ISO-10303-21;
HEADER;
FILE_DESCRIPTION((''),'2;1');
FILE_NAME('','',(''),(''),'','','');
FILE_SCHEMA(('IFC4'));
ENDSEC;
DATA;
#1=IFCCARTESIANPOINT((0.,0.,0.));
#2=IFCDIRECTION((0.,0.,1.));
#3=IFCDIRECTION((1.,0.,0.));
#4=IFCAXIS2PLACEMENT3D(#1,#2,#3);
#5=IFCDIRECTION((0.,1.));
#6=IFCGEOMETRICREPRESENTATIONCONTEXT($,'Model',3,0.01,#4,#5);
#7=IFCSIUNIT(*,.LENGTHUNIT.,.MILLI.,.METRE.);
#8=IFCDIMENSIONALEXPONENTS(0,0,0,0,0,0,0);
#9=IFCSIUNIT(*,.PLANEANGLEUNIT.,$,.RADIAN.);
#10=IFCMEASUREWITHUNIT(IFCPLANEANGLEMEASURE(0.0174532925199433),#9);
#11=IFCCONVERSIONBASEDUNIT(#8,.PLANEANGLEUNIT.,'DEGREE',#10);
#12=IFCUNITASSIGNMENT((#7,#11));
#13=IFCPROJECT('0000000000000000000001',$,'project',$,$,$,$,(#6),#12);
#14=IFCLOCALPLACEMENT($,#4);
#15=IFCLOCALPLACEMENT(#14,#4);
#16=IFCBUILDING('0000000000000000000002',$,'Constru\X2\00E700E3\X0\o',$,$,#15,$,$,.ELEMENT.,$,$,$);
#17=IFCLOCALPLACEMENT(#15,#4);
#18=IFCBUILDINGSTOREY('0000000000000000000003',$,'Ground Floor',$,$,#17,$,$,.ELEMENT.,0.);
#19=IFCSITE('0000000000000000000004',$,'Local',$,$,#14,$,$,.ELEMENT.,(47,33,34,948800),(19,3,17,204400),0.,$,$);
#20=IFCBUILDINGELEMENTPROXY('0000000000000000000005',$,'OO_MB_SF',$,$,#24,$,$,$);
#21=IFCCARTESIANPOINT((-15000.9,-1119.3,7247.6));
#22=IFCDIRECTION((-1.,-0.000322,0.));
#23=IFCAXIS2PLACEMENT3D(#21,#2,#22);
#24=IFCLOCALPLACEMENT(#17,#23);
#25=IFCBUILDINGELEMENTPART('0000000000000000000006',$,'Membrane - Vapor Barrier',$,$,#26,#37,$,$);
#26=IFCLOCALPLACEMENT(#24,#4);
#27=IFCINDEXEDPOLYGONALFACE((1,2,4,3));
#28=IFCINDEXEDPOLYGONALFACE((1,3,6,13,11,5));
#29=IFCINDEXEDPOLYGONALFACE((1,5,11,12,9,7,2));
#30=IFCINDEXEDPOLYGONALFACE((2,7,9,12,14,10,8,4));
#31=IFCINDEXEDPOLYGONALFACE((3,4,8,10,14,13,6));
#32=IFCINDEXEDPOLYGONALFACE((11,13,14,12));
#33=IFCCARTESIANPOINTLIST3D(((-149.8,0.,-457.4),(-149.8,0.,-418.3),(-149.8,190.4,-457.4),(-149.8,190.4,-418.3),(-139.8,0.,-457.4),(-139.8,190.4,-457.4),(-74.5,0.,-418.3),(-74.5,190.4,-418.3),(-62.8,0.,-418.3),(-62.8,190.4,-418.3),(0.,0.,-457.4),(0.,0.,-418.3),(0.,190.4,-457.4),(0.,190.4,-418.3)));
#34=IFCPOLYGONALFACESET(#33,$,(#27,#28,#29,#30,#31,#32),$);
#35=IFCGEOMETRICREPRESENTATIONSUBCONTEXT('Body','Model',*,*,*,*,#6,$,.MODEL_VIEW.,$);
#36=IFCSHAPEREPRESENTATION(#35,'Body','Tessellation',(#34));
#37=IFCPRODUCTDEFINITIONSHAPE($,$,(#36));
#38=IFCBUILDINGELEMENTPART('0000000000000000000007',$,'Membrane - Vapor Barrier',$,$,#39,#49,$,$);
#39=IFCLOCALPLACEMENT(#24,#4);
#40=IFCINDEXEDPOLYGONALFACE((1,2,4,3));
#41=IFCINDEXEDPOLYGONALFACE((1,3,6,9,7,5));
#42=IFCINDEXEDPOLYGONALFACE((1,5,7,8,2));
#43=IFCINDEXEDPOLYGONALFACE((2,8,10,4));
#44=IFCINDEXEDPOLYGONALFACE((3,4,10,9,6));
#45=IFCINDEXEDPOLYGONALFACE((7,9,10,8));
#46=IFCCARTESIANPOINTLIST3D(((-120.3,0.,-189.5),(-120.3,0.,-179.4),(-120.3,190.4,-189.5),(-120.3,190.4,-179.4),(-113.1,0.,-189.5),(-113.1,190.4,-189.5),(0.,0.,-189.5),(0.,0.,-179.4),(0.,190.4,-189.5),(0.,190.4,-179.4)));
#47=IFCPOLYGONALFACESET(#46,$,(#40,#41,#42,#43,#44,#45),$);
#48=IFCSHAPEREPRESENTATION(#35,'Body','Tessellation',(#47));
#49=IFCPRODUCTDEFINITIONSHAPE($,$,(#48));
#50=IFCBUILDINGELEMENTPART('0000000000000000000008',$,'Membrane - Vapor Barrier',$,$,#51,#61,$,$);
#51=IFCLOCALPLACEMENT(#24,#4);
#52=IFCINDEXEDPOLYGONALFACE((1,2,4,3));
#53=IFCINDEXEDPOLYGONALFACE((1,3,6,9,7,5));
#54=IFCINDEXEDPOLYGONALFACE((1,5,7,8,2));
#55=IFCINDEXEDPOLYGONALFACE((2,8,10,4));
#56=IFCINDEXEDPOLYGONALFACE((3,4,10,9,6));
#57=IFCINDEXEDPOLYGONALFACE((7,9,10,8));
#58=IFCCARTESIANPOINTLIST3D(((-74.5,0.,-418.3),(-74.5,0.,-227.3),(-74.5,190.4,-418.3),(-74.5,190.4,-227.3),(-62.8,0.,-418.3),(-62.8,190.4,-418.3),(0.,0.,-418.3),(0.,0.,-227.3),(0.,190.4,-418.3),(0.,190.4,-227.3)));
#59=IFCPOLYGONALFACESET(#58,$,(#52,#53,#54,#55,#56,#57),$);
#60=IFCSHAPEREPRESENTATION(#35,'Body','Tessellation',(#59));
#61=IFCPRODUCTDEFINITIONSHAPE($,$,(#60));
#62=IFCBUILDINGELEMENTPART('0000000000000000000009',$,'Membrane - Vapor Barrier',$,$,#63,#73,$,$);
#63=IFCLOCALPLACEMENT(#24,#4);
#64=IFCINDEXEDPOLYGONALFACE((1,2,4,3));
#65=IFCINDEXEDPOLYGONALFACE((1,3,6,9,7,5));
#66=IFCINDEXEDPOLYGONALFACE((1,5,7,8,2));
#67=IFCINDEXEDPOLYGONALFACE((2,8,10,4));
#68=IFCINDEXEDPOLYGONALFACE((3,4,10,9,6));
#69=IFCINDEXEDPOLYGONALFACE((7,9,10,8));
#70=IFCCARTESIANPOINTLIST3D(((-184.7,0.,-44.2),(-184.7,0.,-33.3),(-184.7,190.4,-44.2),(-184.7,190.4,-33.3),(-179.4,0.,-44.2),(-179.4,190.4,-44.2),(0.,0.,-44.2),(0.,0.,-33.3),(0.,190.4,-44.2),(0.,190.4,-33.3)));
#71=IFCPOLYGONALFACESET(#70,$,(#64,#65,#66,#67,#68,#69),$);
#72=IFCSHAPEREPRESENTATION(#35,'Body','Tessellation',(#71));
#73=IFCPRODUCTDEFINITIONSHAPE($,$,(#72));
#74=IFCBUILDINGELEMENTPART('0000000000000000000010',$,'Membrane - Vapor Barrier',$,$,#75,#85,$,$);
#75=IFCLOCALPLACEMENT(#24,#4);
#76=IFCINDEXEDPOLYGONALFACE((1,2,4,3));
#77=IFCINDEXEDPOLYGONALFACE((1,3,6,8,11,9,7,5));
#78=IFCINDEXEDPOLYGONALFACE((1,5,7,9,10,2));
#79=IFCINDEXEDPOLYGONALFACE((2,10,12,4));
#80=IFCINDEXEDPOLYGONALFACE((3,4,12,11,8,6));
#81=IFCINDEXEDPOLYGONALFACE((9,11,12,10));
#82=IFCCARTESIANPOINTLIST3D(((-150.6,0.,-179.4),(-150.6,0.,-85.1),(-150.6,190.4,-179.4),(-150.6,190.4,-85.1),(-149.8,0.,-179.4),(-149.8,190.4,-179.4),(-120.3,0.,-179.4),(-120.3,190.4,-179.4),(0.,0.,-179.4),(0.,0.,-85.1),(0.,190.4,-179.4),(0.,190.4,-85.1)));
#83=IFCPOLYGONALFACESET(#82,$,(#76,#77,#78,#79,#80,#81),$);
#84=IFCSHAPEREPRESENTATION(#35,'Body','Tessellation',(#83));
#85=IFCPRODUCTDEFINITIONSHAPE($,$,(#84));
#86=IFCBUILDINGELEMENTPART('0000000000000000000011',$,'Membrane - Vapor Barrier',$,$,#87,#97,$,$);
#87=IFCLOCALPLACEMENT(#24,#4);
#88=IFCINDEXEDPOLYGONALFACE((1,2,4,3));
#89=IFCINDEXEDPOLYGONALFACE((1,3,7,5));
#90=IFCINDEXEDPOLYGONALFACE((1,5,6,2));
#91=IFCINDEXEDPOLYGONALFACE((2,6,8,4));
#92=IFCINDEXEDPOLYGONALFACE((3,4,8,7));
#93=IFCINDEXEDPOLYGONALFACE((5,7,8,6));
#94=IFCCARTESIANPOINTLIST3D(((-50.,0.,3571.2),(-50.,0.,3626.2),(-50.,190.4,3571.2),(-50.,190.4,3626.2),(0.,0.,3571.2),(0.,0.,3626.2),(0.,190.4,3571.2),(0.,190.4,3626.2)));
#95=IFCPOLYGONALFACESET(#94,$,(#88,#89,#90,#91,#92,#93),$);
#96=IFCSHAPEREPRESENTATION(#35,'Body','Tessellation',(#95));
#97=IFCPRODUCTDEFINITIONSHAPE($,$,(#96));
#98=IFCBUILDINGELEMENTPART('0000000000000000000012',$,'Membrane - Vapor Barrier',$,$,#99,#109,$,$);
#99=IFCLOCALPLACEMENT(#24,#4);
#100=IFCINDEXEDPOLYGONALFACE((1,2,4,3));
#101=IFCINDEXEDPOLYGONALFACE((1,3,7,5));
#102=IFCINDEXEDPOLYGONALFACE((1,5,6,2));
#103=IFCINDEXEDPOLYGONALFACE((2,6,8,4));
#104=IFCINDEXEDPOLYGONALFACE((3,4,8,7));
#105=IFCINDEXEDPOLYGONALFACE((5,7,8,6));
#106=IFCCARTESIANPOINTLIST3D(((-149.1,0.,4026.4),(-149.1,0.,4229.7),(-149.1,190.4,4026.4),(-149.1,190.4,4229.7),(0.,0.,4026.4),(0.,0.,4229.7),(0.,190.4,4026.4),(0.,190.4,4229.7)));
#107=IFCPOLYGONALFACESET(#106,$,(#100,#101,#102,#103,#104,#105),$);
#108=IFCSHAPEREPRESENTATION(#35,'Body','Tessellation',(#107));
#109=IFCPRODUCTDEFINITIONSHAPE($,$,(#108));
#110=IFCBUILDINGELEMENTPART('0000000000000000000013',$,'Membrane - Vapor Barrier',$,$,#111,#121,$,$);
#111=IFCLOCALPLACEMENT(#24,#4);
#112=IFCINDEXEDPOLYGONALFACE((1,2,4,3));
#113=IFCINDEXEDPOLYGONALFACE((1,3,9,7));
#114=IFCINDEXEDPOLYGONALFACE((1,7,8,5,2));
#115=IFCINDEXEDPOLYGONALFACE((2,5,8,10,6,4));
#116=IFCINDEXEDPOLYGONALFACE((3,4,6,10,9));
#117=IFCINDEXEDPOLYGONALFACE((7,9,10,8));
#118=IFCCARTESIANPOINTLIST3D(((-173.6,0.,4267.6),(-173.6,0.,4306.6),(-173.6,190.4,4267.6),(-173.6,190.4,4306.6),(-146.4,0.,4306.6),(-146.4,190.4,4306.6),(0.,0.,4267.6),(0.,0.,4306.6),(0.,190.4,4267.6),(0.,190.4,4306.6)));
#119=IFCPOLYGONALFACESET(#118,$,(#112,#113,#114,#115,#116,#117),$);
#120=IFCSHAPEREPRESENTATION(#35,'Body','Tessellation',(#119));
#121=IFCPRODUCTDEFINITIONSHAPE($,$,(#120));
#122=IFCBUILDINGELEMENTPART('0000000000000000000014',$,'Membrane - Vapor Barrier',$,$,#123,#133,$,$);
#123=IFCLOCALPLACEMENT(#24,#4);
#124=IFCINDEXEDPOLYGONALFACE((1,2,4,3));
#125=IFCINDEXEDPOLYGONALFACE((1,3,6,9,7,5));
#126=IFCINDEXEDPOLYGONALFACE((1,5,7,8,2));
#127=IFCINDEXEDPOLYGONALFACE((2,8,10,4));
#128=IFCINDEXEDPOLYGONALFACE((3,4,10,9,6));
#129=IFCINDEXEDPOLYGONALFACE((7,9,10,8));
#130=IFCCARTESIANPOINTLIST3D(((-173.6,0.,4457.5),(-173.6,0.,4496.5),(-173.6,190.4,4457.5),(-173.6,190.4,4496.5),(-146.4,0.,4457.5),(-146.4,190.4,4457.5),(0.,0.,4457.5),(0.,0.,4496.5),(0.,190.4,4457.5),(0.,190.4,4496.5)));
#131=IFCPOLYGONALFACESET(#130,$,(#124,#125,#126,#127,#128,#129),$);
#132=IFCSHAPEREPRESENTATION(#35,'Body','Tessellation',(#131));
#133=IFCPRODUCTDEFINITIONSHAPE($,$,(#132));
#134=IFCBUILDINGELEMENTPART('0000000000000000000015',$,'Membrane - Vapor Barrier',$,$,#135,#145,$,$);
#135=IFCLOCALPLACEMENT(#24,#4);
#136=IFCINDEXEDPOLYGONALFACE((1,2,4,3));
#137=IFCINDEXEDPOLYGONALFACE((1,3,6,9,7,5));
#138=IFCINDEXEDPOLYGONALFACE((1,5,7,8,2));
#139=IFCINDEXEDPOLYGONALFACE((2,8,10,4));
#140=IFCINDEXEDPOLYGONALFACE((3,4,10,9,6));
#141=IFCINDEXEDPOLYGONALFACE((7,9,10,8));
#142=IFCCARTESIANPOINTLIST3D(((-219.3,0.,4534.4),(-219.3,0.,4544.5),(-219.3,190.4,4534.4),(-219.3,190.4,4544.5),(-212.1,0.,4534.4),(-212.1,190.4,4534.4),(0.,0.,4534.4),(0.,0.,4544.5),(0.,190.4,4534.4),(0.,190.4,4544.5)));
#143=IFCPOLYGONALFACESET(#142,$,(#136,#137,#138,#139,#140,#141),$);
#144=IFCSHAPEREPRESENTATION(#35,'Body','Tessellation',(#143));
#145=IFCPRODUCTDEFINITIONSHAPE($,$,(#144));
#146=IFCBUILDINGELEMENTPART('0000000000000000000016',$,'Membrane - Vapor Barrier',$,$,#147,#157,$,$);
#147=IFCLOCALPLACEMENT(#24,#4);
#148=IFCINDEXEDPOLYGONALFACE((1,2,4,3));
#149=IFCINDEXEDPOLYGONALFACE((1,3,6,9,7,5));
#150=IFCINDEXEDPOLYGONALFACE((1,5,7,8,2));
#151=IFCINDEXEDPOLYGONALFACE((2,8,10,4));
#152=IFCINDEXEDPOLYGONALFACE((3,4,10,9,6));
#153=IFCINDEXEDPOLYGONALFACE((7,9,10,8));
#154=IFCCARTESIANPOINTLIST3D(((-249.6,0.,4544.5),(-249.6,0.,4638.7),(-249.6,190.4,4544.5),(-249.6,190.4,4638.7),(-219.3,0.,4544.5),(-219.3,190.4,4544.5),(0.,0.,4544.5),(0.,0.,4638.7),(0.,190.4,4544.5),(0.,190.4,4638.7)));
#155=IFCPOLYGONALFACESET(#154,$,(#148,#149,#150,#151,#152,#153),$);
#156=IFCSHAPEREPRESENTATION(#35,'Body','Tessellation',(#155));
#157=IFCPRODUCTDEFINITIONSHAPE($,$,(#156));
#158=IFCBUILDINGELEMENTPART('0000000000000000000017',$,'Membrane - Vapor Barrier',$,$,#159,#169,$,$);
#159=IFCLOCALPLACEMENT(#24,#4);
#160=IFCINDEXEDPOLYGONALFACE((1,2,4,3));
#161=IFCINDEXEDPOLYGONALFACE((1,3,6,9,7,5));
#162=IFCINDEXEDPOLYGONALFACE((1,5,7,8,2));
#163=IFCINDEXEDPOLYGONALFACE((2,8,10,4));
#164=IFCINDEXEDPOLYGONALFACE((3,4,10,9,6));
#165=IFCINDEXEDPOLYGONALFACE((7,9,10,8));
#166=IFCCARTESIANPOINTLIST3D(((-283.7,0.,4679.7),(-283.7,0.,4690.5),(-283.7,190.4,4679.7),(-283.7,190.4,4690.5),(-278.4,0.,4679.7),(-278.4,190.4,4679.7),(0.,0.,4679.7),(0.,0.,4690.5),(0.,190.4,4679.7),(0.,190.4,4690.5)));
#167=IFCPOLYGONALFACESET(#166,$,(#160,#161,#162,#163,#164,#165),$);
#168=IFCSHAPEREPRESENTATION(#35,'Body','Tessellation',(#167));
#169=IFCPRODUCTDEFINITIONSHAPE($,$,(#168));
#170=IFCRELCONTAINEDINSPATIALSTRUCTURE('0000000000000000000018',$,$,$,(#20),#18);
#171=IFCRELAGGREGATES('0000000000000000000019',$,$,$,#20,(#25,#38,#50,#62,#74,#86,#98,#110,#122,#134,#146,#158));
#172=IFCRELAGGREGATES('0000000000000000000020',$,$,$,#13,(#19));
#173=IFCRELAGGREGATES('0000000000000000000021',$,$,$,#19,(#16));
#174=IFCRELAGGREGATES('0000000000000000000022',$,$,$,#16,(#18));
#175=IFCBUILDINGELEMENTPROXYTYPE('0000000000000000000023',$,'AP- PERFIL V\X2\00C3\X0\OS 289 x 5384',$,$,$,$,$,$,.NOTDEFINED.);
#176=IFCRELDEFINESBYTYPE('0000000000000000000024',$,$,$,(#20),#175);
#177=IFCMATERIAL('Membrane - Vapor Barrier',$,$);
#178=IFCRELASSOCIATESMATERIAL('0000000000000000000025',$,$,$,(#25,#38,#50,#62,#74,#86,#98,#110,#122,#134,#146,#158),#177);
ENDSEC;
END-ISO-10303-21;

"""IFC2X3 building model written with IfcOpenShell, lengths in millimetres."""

from ifc_helpers import new_model, entity, si_unit, converted_unit, direction, frame, origin_with_axes, place, context, subcontext, project, spatial, polyline, outline, extrude, material, type_object, element, aggregate, save


model = new_model("IFC2X3")

# Units and contexts
model_context = context("Model", 3, precision=0.01, world=origin_with_axes(), true_north=direction((0.0, 1.0)))
body_context = subcontext(model_context, "Body", "Model", "MODEL_VIEW")
ifc_project = project(units=[si_unit("LENGTHUNIT", "METRE", prefix="MILLI"), converted_unit("PLANEANGLEUNIT", "DEGREE", entity("IfcPlaneAngleMeasure", 0.0174532925199433), si_unit("PLANEANGLEUNIT", "RADIAN"), dimensions=[0, 0, 0, 0, 0, 0, 0])], contexts=[model_context])

# Site, building, storey
site_placement = place(None, origin_with_axes())
site = spatial("IfcSite", under=ifc_project, at=site_placement, Name="Local", CompositionType="ELEMENT", RefLatitude=(47, 33, 34, 948800), RefLongitude=(19, 3, 17, 204400), RefElevation=0.0)
building_placement = place(site_placement, origin_with_axes())
building = spatial("IfcBuilding", under=site, at=building_placement, Name="Construção", CompositionType="ELEMENT")
storey_placement = place(building_placement, origin_with_axes())
storey = spatial("IfcBuildingStorey", under=building, at=storey_placement, Name="Ground Floor", CompositionType="ELEMENT", Elevation=0.0)

# Building element proxy
building_element_proxy_type = type_object("IfcBuildingElementProxyType", Name="AP- PERFIL VÃOS 289 x 5384", PredefinedType="NOTDEFINED")
ifc_material = material(Name="Membrane - Vapor Barrier")
proxy_1_placement = place(storey_placement, frame((-15000.9, -1119.3, 7247.6), z_axis=(0.0, 0.0, 1.0), x_axis=(-1.0, -0.000322, 0.0)))
proxy_1 = element("IfcBuildingElementProxy", 1, at=proxy_1_placement, inside=storey, type_object=building_element_proxy_type, Name="OO_MB_SF")

# Building element parts
building_element_part_1_placement = place(proxy_1_placement, origin_with_axes())
building_element_part_1 = element("IfcBuildingElementPart", 2, at=building_element_part_1_placement, material=ifc_material, Name="Membrane - Vapor Barrier", context=body_context, shape_type="SweptSolid", body=[
    extrude(outline(polyline([(62.8, -418.3), (0.0, -418.3), (0.0, -457.4), (139.8, -457.4), (149.8, -457.4), (149.8, -418.3), (74.5, -418.3), (62.8, -418.3)])), frame((0.0, 190.4, 0.0), z_axis=(0.0, 1.0, 0.0), x_axis=(-1.0, 0.0, 0.0)), (0.0, 0.0, -1.0), 190.4),
])
building_element_part_2_placement = place(proxy_1_placement, origin_with_axes())
building_element_part_2 = element("IfcBuildingElementPart", 3, at=building_element_part_2_placement, material=ifc_material, Name="Membrane - Vapor Barrier", context=body_context, shape_type="SweptSolid", body=[
    extrude(outline(polyline([(120.3, -179.4), (0.0, -179.4), (0.0, -189.5), (113.1, -189.5), (120.3, -189.5), (120.3, -179.4)])), frame((0.0, 190.4, 0.0), z_axis=(0.0, 1.0, 0.0), x_axis=(-1.0, 0.0, 0.0)), (0.0, 0.0, -1.0), 190.4),
])
building_element_part_3_placement = place(proxy_1_placement, origin_with_axes())
building_element_part_3 = element("IfcBuildingElementPart", 4, at=building_element_part_3_placement, material=ifc_material, Name="Membrane - Vapor Barrier", context=body_context, shape_type="SweptSolid", body=[
    extrude(outline(polyline([(0.0, -227.3), (0.0, -418.3), (62.8, -418.3), (74.5, -418.3), (74.5, -227.3), (0.0, -227.3)])), frame((0.0, 190.4, 0.0), z_axis=(0.0, 1.0, 0.0), x_axis=(-1.0, 0.0, 0.0)), (0.0, 0.0, -1.0), 190.4),
])
building_element_part_4_placement = place(proxy_1_placement, origin_with_axes())
building_element_part_4 = element("IfcBuildingElementPart", 5, at=building_element_part_4_placement, material=ifc_material, Name="Membrane - Vapor Barrier", context=body_context, shape_type="SweptSolid", body=[
    extrude(outline(polyline([(184.7, -33.3), (0.0, -33.3), (0.0, -44.2), (179.4, -44.2), (184.7, -44.2), (184.7, -33.3)])), frame((0.0, 190.4, 0.0), z_axis=(0.0, 1.0, 0.0), x_axis=(-1.0, 0.0, 0.0)), (0.0, 0.0, -1.0), 190.4),
])
building_element_part_5_placement = place(proxy_1_placement, origin_with_axes())
building_element_part_5 = element("IfcBuildingElementPart", 6, at=building_element_part_5_placement, material=ifc_material, Name="Membrane - Vapor Barrier", context=body_context, shape_type="SweptSolid", body=[
    extrude(outline(polyline([(0.0, -85.1), (0.0, -179.4), (120.3, -179.4), (149.8, -179.4), (150.6, -179.4), (150.6, -85.1), (0.0, -85.1)])), frame((0.0, 190.4, 0.0), z_axis=(0.0, 1.0, 0.0), x_axis=(-1.0, 0.0, 0.0)), (0.0, 0.0, -1.0), 190.4),
])
building_element_part_6_placement = place(proxy_1_placement, origin_with_axes())
building_element_part_6 = element("IfcBuildingElementPart", 7, at=building_element_part_6_placement, material=ifc_material, Name="Membrane - Vapor Barrier", context=body_context, shape_type="SweptSolid", body=[
    extrude(outline(polyline([(0.0, 3571.2), (50.0, 3571.2), (50.0, 3626.2), (0.0, 3626.2), (0.0, 3571.2)])), frame((0.0, 190.4, 0.0), z_axis=(0.0, 1.0, 0.0), x_axis=(-1.0, 0.0, 0.0)), (0.0, 0.0, -1.0), 190.4),
])
building_element_part_7_placement = place(proxy_1_placement, origin_with_axes())
building_element_part_7 = element("IfcBuildingElementPart", 8, at=building_element_part_7_placement, material=ifc_material, Name="Membrane - Vapor Barrier", context=body_context, shape_type="SweptSolid", body=[
    extrude(outline(polyline([(149.1, 4229.7), (0.0, 4229.7), (0.0, 4026.4), (149.1, 4026.4), (149.1, 4229.7)])), frame((0.0, 190.4, 0.0), z_axis=(0.0, 1.0, 0.0), x_axis=(-1.0, 0.0, 0.0)), (0.0, 0.0, -1.0), 190.4),
])
building_element_part_8_placement = place(proxy_1_placement, origin_with_axes())
building_element_part_8 = element("IfcBuildingElementPart", 9, at=building_element_part_8_placement, material=ifc_material, Name="Membrane - Vapor Barrier", context=body_context, shape_type="SweptSolid", body=[
    extrude(outline(polyline([(0.0, 4306.6), (0.0, 4267.6), (173.6, 4267.6), (173.6, 4306.6), (146.4, 4306.6), (0.0, 4306.6)])), frame((0.0, 190.4, 0.0), z_axis=(0.0, 1.0, 0.0), x_axis=(-1.0, 0.0, 0.0)), (0.0, 0.0, -1.0), 190.4),
])
building_element_part_9_placement = place(proxy_1_placement, origin_with_axes())
building_element_part_9 = element("IfcBuildingElementPart", 10, at=building_element_part_9_placement, material=ifc_material, Name="Membrane - Vapor Barrier", context=body_context, shape_type="SweptSolid", body=[
    extrude(outline(polyline([(173.6, 4496.5), (0.0, 4496.5), (0.0, 4457.5), (146.4, 4457.5), (173.6, 4457.5), (173.6, 4496.5)])), frame((0.0, 190.4, 0.0), z_axis=(0.0, 1.0, 0.0), x_axis=(-1.0, 0.0, 0.0)), (0.0, 0.0, -1.0), 190.4),
])
building_element_part_10_placement = place(proxy_1_placement, origin_with_axes())
building_element_part_10 = element("IfcBuildingElementPart", 11, at=building_element_part_10_placement, material=ifc_material, Name="Membrane - Vapor Barrier", context=body_context, shape_type="SweptSolid", body=[
    extrude(outline(polyline([(0.0, 4534.4), (212.1, 4534.4), (219.3, 4534.4), (219.3, 4544.5), (0.0, 4544.5), (0.0, 4534.4)])), frame((0.0, 190.4, 0.0), z_axis=(0.0, 1.0, 0.0), x_axis=(-1.0, 0.0, 0.0)), (0.0, 0.0, -1.0), 190.4),
])
building_element_part_11_placement = place(proxy_1_placement, origin_with_axes())
building_element_part_11 = element("IfcBuildingElementPart", 12, at=building_element_part_11_placement, material=ifc_material, Name="Membrane - Vapor Barrier", context=body_context, shape_type="SweptSolid", body=[
    extrude(outline(polyline([(249.6, 4638.7), (0.0, 4638.7), (0.0, 4544.5), (219.3, 4544.5), (249.6, 4544.5), (249.6, 4638.7)])), frame((0.0, 190.4, 0.0), z_axis=(0.0, 1.0, 0.0), x_axis=(-1.0, 0.0, 0.0)), (0.0, 0.0, -1.0), 190.4),
])
building_element_part_12_placement = place(proxy_1_placement, origin_with_axes())
building_element_part_12 = element("IfcBuildingElementPart", 13, at=building_element_part_12_placement, material=ifc_material, Name="Membrane - Vapor Barrier", context=body_context, shape_type="SweptSolid", body=[
    extrude(outline(polyline([(0.0, 4679.7), (278.4, 4679.7), (283.7, 4679.7), (283.7, 4690.5), (0.0, 4690.5), (0.0, 4679.7)])), frame((0.0, 190.4, 0.0), z_axis=(0.0, 1.0, 0.0), x_axis=(-1.0, 0.0, 0.0)), (0.0, 0.0, -1.0), 190.4),
])
aggregate(proxy_1, [building_element_part_1, building_element_part_2, building_element_part_3, building_element_part_4, building_element_part_5, building_element_part_6, building_element_part_7, building_element_part_8, building_element_part_9, building_element_part_10, building_element_part_11, building_element_part_12])

save(model, "model.ifc")
